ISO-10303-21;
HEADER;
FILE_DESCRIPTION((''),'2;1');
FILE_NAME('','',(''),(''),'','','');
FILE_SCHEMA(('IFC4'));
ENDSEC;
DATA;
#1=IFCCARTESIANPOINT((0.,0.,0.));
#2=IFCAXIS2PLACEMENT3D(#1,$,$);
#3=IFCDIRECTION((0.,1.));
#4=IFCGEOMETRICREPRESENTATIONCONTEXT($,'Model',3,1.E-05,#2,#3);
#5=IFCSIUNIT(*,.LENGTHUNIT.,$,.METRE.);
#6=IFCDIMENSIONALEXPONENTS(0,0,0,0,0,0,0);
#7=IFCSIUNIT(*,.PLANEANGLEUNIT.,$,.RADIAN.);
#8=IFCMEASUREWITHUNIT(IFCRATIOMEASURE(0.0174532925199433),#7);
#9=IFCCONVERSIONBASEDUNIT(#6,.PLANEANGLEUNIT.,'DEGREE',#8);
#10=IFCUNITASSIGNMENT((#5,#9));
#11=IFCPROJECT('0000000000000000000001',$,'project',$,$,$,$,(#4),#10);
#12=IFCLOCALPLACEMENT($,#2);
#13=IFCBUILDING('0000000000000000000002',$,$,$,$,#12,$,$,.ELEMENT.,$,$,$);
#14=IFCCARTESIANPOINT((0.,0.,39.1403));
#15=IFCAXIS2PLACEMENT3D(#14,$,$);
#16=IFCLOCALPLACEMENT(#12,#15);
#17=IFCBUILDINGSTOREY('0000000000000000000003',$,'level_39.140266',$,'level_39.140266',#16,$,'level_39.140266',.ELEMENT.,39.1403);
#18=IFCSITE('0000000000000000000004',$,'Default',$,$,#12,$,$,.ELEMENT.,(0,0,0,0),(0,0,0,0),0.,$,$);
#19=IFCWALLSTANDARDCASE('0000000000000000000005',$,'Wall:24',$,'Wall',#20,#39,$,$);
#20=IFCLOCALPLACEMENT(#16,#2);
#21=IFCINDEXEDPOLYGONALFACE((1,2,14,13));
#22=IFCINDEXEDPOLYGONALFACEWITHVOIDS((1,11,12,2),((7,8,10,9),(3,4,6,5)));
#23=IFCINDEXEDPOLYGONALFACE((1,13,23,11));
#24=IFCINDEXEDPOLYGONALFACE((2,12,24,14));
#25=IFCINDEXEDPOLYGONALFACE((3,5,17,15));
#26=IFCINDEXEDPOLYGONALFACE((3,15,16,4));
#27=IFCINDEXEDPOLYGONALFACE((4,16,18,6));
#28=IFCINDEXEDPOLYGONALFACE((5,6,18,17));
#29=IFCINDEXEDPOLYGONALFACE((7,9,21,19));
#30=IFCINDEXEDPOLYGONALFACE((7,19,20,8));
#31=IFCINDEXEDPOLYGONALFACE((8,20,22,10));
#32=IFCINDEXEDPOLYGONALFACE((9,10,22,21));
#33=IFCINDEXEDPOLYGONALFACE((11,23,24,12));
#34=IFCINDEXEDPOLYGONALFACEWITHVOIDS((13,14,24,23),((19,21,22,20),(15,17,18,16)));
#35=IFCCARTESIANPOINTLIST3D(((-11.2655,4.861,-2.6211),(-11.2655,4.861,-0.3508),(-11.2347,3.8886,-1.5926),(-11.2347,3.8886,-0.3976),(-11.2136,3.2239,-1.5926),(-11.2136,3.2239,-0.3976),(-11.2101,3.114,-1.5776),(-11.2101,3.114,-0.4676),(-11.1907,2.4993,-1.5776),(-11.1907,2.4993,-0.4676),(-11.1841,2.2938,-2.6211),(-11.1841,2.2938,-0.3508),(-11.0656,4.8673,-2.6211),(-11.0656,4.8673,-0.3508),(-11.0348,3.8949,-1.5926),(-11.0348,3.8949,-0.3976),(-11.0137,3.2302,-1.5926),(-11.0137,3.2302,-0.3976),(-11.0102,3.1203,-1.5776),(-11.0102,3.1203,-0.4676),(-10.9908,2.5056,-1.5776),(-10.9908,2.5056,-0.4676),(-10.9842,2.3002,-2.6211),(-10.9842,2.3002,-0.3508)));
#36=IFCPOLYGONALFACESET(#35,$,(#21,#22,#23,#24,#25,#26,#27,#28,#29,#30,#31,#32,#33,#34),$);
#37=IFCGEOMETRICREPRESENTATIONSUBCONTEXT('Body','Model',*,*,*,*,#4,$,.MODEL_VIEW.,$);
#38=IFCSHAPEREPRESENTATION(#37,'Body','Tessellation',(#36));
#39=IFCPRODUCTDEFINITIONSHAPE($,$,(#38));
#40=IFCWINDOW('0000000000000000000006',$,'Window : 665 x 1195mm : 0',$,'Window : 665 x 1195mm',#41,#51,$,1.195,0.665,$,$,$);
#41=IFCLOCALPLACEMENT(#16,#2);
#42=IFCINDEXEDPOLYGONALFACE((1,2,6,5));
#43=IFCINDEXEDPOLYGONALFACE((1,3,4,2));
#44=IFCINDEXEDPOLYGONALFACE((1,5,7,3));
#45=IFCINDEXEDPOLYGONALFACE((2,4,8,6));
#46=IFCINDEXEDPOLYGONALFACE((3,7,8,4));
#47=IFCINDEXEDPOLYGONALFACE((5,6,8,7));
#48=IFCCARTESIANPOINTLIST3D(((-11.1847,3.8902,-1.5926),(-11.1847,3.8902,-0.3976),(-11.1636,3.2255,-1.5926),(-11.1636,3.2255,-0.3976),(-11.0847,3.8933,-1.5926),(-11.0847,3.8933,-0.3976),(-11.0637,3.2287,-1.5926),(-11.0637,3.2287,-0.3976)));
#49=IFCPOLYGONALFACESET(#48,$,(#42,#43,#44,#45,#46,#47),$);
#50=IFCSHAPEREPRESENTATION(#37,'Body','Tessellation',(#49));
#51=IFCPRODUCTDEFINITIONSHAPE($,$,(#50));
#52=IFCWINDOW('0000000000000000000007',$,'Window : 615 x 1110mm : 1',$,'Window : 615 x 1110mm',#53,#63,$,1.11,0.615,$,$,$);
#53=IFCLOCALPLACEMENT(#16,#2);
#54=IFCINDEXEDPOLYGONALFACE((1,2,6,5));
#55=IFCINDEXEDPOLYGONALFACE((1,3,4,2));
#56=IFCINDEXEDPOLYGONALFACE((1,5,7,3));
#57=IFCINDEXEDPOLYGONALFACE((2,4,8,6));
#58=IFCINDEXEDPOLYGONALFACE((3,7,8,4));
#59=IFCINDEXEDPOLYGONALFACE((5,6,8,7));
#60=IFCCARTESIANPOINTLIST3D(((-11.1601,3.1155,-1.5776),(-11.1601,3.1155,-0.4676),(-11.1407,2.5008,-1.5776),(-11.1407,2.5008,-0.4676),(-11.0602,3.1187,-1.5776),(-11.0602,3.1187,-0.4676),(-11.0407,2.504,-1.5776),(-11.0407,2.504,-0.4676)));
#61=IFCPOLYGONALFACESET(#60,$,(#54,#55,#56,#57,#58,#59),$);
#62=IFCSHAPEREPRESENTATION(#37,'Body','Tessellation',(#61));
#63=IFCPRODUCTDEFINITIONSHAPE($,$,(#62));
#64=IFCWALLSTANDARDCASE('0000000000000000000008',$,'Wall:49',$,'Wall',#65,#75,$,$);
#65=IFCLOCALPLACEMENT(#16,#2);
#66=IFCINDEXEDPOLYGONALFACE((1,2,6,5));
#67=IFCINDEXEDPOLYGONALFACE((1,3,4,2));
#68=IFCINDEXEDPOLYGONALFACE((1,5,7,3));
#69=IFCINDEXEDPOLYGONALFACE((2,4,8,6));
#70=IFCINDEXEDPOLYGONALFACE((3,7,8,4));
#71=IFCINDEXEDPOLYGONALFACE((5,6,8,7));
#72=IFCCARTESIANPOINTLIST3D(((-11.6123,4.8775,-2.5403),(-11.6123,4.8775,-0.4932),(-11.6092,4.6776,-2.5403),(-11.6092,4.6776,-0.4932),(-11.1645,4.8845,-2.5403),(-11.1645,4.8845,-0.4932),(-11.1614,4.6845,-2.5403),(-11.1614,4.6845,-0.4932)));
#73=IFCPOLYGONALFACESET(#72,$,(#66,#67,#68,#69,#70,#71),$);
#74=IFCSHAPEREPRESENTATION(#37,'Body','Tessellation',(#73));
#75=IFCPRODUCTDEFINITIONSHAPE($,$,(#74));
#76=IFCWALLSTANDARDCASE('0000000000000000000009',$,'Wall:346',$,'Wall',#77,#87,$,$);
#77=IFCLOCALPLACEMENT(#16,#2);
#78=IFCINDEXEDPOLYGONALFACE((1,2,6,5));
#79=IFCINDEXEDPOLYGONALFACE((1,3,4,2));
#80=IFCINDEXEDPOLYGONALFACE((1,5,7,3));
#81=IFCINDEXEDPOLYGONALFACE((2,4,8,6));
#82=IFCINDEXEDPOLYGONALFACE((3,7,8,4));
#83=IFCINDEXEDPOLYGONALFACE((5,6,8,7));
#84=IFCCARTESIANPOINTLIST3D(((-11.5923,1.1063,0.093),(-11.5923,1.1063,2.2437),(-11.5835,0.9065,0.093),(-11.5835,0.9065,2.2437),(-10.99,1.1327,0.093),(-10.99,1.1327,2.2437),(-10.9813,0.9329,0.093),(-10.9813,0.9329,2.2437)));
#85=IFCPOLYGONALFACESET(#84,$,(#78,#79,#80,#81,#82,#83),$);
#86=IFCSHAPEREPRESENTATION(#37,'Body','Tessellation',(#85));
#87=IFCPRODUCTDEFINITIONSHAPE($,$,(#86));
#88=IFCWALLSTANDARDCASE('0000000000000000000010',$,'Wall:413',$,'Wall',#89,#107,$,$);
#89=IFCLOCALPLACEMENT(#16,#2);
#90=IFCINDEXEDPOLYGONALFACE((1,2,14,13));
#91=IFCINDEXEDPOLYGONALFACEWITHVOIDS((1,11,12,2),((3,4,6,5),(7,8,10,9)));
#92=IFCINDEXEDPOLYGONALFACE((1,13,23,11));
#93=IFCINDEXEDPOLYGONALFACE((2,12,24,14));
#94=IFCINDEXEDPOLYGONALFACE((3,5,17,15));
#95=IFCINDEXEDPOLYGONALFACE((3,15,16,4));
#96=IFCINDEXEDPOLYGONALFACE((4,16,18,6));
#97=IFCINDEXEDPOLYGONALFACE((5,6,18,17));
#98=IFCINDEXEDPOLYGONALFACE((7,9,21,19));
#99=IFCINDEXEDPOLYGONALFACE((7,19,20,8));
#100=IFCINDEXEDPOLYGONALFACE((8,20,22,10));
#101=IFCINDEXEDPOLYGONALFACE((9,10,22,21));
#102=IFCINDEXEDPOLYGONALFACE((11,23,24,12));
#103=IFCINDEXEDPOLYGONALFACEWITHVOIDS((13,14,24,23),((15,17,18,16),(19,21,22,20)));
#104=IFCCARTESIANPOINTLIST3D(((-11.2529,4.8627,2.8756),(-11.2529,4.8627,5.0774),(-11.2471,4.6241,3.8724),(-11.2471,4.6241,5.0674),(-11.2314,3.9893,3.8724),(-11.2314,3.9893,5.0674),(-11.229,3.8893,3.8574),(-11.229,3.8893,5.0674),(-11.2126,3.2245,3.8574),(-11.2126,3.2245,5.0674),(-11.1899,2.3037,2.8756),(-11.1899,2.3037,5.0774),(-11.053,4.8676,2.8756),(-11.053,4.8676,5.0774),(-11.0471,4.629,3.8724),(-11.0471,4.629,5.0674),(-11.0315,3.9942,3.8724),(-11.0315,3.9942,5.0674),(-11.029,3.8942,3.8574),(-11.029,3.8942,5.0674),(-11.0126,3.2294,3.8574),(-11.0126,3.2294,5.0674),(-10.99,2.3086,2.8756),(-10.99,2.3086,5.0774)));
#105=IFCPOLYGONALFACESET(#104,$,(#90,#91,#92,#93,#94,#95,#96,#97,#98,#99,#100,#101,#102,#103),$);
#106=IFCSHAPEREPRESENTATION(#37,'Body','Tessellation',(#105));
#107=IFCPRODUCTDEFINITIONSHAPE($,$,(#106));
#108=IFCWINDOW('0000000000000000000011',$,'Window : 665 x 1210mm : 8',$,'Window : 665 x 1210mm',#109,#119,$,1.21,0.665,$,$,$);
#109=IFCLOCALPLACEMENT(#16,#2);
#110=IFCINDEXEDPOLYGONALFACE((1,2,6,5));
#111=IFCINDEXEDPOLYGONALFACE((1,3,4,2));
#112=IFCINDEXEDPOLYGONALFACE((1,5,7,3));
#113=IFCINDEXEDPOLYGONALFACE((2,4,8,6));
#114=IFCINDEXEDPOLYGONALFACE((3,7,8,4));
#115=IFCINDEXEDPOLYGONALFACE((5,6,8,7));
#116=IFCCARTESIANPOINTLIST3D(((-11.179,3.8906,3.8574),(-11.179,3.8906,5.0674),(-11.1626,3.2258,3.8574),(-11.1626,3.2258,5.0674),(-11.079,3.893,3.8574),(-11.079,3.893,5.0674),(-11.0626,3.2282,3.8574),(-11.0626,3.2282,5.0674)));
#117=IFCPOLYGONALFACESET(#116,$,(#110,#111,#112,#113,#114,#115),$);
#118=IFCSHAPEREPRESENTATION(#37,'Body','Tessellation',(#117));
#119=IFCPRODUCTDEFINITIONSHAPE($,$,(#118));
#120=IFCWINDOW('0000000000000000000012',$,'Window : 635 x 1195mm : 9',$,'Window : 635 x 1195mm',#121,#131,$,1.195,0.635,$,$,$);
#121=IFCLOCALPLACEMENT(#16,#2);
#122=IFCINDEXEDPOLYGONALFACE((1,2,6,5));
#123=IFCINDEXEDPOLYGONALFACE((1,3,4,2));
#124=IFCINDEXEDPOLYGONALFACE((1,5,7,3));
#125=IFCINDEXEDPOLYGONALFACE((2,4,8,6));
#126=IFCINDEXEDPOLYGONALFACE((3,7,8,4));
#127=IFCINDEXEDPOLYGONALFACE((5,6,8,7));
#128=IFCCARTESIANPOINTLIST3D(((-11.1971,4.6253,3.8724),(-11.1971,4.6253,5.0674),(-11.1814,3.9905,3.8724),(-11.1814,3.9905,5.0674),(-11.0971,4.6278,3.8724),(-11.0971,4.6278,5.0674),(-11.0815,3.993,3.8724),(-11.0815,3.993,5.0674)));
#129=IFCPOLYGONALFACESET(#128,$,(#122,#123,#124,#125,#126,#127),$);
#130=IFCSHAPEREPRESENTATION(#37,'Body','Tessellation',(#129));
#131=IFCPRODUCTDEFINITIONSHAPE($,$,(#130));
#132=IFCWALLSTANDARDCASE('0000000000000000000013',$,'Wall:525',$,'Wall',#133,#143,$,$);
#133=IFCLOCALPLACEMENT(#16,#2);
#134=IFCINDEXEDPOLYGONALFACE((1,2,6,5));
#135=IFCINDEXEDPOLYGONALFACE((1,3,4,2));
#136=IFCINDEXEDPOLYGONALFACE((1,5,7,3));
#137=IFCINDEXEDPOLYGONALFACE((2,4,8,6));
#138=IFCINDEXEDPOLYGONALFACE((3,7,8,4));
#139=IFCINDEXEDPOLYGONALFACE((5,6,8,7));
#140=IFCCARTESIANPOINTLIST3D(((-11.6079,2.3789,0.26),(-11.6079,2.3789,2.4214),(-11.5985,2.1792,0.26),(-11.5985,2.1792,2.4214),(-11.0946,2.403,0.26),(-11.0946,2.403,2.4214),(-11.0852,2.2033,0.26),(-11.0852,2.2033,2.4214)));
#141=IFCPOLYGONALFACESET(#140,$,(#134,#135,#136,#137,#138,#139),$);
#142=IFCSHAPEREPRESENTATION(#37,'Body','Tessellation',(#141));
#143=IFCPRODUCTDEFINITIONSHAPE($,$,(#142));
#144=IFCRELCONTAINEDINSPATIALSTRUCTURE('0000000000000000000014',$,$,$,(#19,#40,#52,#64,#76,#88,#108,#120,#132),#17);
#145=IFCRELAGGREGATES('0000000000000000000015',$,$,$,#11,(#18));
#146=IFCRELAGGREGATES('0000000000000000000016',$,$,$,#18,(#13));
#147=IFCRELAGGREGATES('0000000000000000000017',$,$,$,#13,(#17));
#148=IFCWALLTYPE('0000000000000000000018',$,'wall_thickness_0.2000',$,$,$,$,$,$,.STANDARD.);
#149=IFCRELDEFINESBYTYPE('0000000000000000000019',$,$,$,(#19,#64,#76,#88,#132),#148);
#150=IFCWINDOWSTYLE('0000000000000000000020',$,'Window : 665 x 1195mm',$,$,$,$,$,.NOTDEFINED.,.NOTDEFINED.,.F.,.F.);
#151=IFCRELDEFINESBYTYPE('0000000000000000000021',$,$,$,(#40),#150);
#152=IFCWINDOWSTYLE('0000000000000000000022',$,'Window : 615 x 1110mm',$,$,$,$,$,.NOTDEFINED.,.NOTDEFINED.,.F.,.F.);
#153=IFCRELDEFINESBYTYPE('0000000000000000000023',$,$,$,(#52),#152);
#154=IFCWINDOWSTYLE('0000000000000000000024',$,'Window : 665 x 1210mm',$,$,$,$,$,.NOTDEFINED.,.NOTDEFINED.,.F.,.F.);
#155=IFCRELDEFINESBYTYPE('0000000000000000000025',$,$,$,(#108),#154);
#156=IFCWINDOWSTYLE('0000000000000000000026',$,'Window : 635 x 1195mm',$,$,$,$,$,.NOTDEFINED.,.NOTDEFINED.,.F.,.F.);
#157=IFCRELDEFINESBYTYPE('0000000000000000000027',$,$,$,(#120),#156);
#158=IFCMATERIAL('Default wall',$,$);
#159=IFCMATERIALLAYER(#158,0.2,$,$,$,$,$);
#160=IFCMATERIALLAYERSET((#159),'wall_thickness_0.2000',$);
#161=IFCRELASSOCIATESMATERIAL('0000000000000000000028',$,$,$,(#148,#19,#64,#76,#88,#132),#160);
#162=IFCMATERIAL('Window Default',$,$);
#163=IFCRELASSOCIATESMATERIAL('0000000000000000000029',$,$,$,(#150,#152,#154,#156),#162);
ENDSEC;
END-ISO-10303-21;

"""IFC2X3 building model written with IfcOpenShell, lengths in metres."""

from ifc_helpers import new_model, entity, si_unit, converted_unit, direction, frame, frame_2d, origin, origin_2d_with_axis, place, context, subcontext, project, spatial, polyline, rectangle, outline, extrude, source, transform, mapped, material, layer, layer_set, layer_usage, type_object, type_shapes, element, fill, save


model = new_model("IFC2X3")

# Units and contexts
model_context = context("Model", 3, precision=1e-05, world=origin(), true_north=direction((0.0, 1.0)))
body_context = subcontext(model_context, "Body", "Model", "MODEL_VIEW")
ifc_project = project(units=[si_unit("LENGTHUNIT", "METRE"), converted_unit("PLANEANGLEUNIT", "DEGREE", entity("IfcRatioMeasure", 0.0174532925199433), si_unit("PLANEANGLEUNIT", "RADIAN"), dimensions=[0, 0, 0, 0, 0, 0, 0])], contexts=[model_context])

# Site, building, storey
placement_1 = place(None, origin())
site = spatial("IfcSite", under=ifc_project, at=placement_1, Name="Default", CompositionType="ELEMENT", RefLatitude=(0, 0, 0, 0), RefLongitude=(0, 0, 0, 0), RefElevation=0.0)
building = spatial("IfcBuilding", under=site, at=placement_1, CompositionType="ELEMENT")
storey_placement = place(placement_1, frame((0.0, 0.0, 39.1403)))
storey = spatial("IfcBuildingStorey", under=building, at=storey_placement, Name="level_39.140266", ObjectType="level_39.140266", LongName="level_39.140266", CompositionType="ELEMENT", Elevation=39.1403)

# Wall, openings, windows
ifc_material_1 = material(Name="Default wall")
ifc_layer = layer(ifc_material_1, 0.2)
ifc_layer_set = layer_set([ifc_layer], Name="wall_thickness_0.2000")
ifc_layer_usage = layer_usage(ifc_layer_set, "AXIS2", "POSITIVE", -0.1)
wall_type = type_object("IfcWallType", Name="wall_thickness_0.2000", PredefinedType="STANDARD", material=ifc_layer_set)
placement_2 = place(placement_1, frame((0.0, 0.0, 36.5192)))
wall_1_placement = place(placement_2, frame((-11.0842, 2.297, 0.0), z_axis=(0.0, 0.0, 1.0), x_axis=(-0.031655, 0.999499, 0.0)))
wall_1 = element("IfcWallStandardCase", 1, at=wall_1_placement, inside=storey, type_object=wall_type, material=ifc_layer_usage, Name="Wall:24", ObjectType="Wall", context=body_context, shape_type="SweptSolid", body=[
    extrude(outline(polyline([(2.5685, -0.1), (2.5685, 0.1), (0.0, 0.1), (0.0, -0.1), (2.5685, -0.1)])), origin(), (0.0, 0.0, 1.0), 2.2703),
])
opening_1_placement = place(wall_1_placement, frame((0.9305, -0.1, 1.0285)))
opening_1 = element("IfcOpeningElement", 2, at=opening_1_placement, cuts=wall_1, ObjectType="Opening", context=body_context, shape_type="SweptSolid", body=[
    extrude(rectangle(XDim=0.665, YDim=1.195, at=frame_2d((0.5975, 0.3325), x_axis=(0.0, 1.0))), frame((0.0, 0.0, 0.0), z_axis=(0.0, 1.0, 0.0), x_axis=(0.0, 0.0, 1.0)), (0.0, 0.0, 1.0), 0.2),
])
opening_2_placement = place(wall_1_placement, frame((0.2055, -0.1, 1.0435)))
opening_2 = element("IfcOpeningElement", 3, at=opening_2_placement, cuts=wall_1, ObjectType="Opening", context=body_context, shape_type="SweptSolid", body=[
    extrude(rectangle(XDim=0.615, YDim=1.11, at=frame_2d((0.555, 0.3075), x_axis=(0.0, 1.0))), frame((0.0, 0.0, 0.0), z_axis=(0.0, 1.0, 0.0), x_axis=(0.0, 0.0, 1.0)), (0.0, 0.0, 1.0), 0.2),
])
ifc_material_2 = material(Name="Window Default")
window_style_1 = type_object("IfcWindowStyle", Name="Window : 665 x 1195mm", ConstructionType="NOTDEFINED", OperationType="NOTDEFINED", ParameterTakesPrecedence=False, Sizeable=False, material=ifc_material_2)
shared_shape_1 = source(origin(), body_context, "Body", "SweptSolid", [
    extrude(rectangle(XDim=0.1, YDim=0.665, at=origin_2d_with_axis()), frame((0.3325, 0.1, 0.0), z_axis=(0.0, 0.0, 1.0), x_axis=(0.0, 1.0, 0.0)), (0.0, 0.0, 1.0), 1.195),
])
type_shapes(window_style_1, [shared_shape_1])
window_1_placement = place(opening_1_placement, origin())
window_1 = element("IfcWindow", 4, at=window_1_placement, inside=storey, type_object=window_style_1, Name="Window : 665 x 1195mm : 0", ObjectType="Window : 665 x 1195mm", OverallHeight=1.195, OverallWidth=0.665, context=body_context, shape_type="MappedRepresentation", body=[
    mapped(shared_shape_1, transform((0.0, 0.0, 0.0), scale=1.0)),
])
fill(opening_1, window_1)
window_style_2 = type_object("IfcWindowStyle", Name="Window : 615 x 1110mm", ConstructionType="NOTDEFINED", OperationType="NOTDEFINED", ParameterTakesPrecedence=False, Sizeable=False, material=ifc_material_2)
shared_shape_2 = source(origin(), body_context, "Body", "SweptSolid", [
    extrude(rectangle(XDim=0.1, YDim=0.615, at=origin_2d_with_axis()), frame((0.3075, 0.1, 0.0), z_axis=(0.0, 0.0, 1.0), x_axis=(0.0, 1.0, 0.0)), (0.0, 0.0, 1.0), 1.11),
])
type_shapes(window_style_2, [shared_shape_2])
window_2_placement = place(opening_2_placement, origin())
window_2 = element("IfcWindow", 5, at=window_2_placement, inside=storey, type_object=window_style_2, Name="Window : 615 x 1110mm : 1", ObjectType="Window : 615 x 1110mm", OverallHeight=1.11, OverallWidth=0.615, context=body_context, shape_type="MappedRepresentation", body=[
    mapped(shared_shape_2, transform((0.0, 0.0, 0.0), scale=1.0)),
])
fill(opening_2, window_2)

# Walls
placement_3 = place(placement_1, frame((0.0, 0.0, 36.6)))
wall_2_placement = place(placement_3, frame((-11.163, 4.7845, 0.0), z_axis=(0.0, 0.0, 1.0), x_axis=(-0.999879, -0.015578, 0.0)))
element("IfcWallStandardCase", 6, at=wall_2_placement, inside=storey, type_object=wall_type, material=ifc_layer_usage, Name="Wall:49", ObjectType="Wall", context=body_context, shape_type="SweptSolid", body=[
    extrude(outline(polyline([(0.4478, -0.1), (0.4478, 0.1), (0.0, 0.1), (0.0, -0.1), (0.4478, -0.1)])), origin(), (0.0, 0.0, 1.0), 2.0471),
])
placement_4 = place(placement_1, frame((0.0, 0.0, 39.2333)))
wall_3_placement = place(placement_4, frame((-10.9857, 1.0328, 0.0), z_axis=(0.0, 0.0, 1.0), x_axis=(-0.999039, -0.043838, 0.0)))
element("IfcWallStandardCase", 7, at=wall_3_placement, inside=storey, type_object=wall_type, material=ifc_layer_usage, Name="Wall:346", ObjectType="Wall", context=body_context, shape_type="SweptSolid", body=[
    extrude(outline(polyline([(0.6028, -0.1), (0.6028, 0.1), (0.0, 0.1), (0.0, -0.1), (0.6028, -0.1)])), origin(), (0.0, 0.0, 1.0), 2.1507),
])

# Wall, openings, windows
placement_5 = place(placement_1, frame((0.0, 0.0, 42.0159)))
wall_4_placement = place(placement_5, frame((-11.0899, 2.3062, 0.0), z_axis=(0.0, 0.0, 1.0), x_axis=(-0.024625, 0.999697, 0.0)))
wall_4 = element("IfcWallStandardCase", 8, at=wall_4_placement, inside=storey, type_object=wall_type, material=ifc_layer_usage, Name="Wall:413", ObjectType="Wall", context=body_context, shape_type="SweptSolid", body=[
    extrude(outline(polyline([(2.5598, -0.1), (2.5598, 0.1), (0.0, 0.1), (0.0, -0.1), (2.5598, -0.1)])), origin(), (0.0, 0.0, 1.0), 2.2018),
])
opening_3_placement = place(wall_4_placement, frame((0.9211, -0.1, 0.9818)))
opening_3 = element("IfcOpeningElement", 9, at=opening_3_placement, cuts=wall_4, ObjectType="Opening", context=body_context, shape_type="SweptSolid", body=[
    extrude(rectangle(XDim=0.665, YDim=1.21, at=frame_2d((0.605, 0.3325), x_axis=(0.0, 1.0))), frame((0.0, 0.0, 0.0), z_axis=(0.0, 1.0, 0.0), x_axis=(0.0, 0.0, 1.0)), (0.0, 0.0, 1.0), 0.2),
])
opening_4_placement = place(wall_4_placement, frame((1.6861, -0.1, 0.9968)))
opening_4 = element("IfcOpeningElement", 10, at=opening_4_placement, cuts=wall_4, ObjectType="Opening", context=body_context, shape_type="SweptSolid", body=[
    extrude(rectangle(XDim=0.635, YDim=1.195, at=frame_2d((0.5975, 0.3175), x_axis=(0.0, 1.0))), frame((0.0, 0.0, 0.0), z_axis=(0.0, 1.0, 0.0), x_axis=(0.0, 0.0, 1.0)), (0.0, 0.0, 1.0), 0.2),
])
window_style_3 = type_object("IfcWindowStyle", Name="Window : 665 x 1210mm", ConstructionType="NOTDEFINED", OperationType="NOTDEFINED", ParameterTakesPrecedence=False, Sizeable=False, material=ifc_material_2)
shared_shape_3 = source(origin(), body_context, "Body", "SweptSolid", [
    extrude(rectangle(XDim=0.1, YDim=0.665, at=origin_2d_with_axis()), frame((0.3325, 0.1, 0.0), z_axis=(0.0, 0.0, 1.0), x_axis=(0.0, 1.0, 0.0)), (0.0, 0.0, 1.0), 1.21),
])
type_shapes(window_style_3, [shared_shape_3])
window_3_placement = place(opening_3_placement, origin())
window_3 = element("IfcWindow", 11, at=window_3_placement, inside=storey, type_object=window_style_3, Name="Window : 665 x 1210mm : 8", ObjectType="Window : 665 x 1210mm", OverallHeight=1.21, OverallWidth=0.665, context=body_context, shape_type="MappedRepresentation", body=[
    mapped(shared_shape_3, transform((0.0, 0.0, 0.0), scale=1.0)),
])
fill(opening_3, window_3)
window_style_4 = type_object("IfcWindowStyle", Name="Window : 635 x 1195mm", ConstructionType="NOTDEFINED", OperationType="NOTDEFINED", ParameterTakesPrecedence=False, Sizeable=False, material=ifc_material_2)
shared_shape_4 = source(origin(), body_context, "Body", "SweptSolid", [
    extrude(rectangle(XDim=0.1, YDim=0.635, at=origin_2d_with_axis()), frame((0.3175, 0.1, 0.0), z_axis=(0.0, 0.0, 1.0), x_axis=(0.0, 1.0, 0.0)), (0.0, 0.0, 1.0), 1.195),
])
type_shapes(window_style_4, [shared_shape_4])
window_4_placement = place(opening_4_placement, origin())
window_4 = element("IfcWindow", 12, at=window_4_placement, inside=storey, type_object=window_style_4, Name="Window : 635 x 1195mm : 9", ObjectType="Window : 635 x 1195mm", OverallHeight=1.195, OverallWidth=0.635, context=body_context, shape_type="MappedRepresentation", body=[
    mapped(shared_shape_4, transform((0.0, 0.0, 0.0), scale=1.0)),
])
fill(opening_4, window_4)

# Wall
placement_6 = place(placement_1, frame((0.0, 0.0, 39.4003)))
wall_5_placement = place(placement_6, frame((-11.0899, 2.3032, 0.0), z_axis=(0.0, 0.0, 1.0), x_axis=(-0.9989, -0.046895, 0.0)))
element("IfcWallStandardCase", 13, at=wall_5_placement, inside=storey, type_object=wall_type, material=ifc_layer_usage, Name="Wall:525", ObjectType="Wall", context=body_context, shape_type="SweptSolid", body=[
    extrude(outline(polyline([(0.5139, -0.1), (0.5139, 0.1), (0.0, 0.1), (0.0, -0.1), (0.5139, -0.1)])), origin(), (0.0, 0.0, 1.0), 2.1614),
])

save(model, "model.ifc")
